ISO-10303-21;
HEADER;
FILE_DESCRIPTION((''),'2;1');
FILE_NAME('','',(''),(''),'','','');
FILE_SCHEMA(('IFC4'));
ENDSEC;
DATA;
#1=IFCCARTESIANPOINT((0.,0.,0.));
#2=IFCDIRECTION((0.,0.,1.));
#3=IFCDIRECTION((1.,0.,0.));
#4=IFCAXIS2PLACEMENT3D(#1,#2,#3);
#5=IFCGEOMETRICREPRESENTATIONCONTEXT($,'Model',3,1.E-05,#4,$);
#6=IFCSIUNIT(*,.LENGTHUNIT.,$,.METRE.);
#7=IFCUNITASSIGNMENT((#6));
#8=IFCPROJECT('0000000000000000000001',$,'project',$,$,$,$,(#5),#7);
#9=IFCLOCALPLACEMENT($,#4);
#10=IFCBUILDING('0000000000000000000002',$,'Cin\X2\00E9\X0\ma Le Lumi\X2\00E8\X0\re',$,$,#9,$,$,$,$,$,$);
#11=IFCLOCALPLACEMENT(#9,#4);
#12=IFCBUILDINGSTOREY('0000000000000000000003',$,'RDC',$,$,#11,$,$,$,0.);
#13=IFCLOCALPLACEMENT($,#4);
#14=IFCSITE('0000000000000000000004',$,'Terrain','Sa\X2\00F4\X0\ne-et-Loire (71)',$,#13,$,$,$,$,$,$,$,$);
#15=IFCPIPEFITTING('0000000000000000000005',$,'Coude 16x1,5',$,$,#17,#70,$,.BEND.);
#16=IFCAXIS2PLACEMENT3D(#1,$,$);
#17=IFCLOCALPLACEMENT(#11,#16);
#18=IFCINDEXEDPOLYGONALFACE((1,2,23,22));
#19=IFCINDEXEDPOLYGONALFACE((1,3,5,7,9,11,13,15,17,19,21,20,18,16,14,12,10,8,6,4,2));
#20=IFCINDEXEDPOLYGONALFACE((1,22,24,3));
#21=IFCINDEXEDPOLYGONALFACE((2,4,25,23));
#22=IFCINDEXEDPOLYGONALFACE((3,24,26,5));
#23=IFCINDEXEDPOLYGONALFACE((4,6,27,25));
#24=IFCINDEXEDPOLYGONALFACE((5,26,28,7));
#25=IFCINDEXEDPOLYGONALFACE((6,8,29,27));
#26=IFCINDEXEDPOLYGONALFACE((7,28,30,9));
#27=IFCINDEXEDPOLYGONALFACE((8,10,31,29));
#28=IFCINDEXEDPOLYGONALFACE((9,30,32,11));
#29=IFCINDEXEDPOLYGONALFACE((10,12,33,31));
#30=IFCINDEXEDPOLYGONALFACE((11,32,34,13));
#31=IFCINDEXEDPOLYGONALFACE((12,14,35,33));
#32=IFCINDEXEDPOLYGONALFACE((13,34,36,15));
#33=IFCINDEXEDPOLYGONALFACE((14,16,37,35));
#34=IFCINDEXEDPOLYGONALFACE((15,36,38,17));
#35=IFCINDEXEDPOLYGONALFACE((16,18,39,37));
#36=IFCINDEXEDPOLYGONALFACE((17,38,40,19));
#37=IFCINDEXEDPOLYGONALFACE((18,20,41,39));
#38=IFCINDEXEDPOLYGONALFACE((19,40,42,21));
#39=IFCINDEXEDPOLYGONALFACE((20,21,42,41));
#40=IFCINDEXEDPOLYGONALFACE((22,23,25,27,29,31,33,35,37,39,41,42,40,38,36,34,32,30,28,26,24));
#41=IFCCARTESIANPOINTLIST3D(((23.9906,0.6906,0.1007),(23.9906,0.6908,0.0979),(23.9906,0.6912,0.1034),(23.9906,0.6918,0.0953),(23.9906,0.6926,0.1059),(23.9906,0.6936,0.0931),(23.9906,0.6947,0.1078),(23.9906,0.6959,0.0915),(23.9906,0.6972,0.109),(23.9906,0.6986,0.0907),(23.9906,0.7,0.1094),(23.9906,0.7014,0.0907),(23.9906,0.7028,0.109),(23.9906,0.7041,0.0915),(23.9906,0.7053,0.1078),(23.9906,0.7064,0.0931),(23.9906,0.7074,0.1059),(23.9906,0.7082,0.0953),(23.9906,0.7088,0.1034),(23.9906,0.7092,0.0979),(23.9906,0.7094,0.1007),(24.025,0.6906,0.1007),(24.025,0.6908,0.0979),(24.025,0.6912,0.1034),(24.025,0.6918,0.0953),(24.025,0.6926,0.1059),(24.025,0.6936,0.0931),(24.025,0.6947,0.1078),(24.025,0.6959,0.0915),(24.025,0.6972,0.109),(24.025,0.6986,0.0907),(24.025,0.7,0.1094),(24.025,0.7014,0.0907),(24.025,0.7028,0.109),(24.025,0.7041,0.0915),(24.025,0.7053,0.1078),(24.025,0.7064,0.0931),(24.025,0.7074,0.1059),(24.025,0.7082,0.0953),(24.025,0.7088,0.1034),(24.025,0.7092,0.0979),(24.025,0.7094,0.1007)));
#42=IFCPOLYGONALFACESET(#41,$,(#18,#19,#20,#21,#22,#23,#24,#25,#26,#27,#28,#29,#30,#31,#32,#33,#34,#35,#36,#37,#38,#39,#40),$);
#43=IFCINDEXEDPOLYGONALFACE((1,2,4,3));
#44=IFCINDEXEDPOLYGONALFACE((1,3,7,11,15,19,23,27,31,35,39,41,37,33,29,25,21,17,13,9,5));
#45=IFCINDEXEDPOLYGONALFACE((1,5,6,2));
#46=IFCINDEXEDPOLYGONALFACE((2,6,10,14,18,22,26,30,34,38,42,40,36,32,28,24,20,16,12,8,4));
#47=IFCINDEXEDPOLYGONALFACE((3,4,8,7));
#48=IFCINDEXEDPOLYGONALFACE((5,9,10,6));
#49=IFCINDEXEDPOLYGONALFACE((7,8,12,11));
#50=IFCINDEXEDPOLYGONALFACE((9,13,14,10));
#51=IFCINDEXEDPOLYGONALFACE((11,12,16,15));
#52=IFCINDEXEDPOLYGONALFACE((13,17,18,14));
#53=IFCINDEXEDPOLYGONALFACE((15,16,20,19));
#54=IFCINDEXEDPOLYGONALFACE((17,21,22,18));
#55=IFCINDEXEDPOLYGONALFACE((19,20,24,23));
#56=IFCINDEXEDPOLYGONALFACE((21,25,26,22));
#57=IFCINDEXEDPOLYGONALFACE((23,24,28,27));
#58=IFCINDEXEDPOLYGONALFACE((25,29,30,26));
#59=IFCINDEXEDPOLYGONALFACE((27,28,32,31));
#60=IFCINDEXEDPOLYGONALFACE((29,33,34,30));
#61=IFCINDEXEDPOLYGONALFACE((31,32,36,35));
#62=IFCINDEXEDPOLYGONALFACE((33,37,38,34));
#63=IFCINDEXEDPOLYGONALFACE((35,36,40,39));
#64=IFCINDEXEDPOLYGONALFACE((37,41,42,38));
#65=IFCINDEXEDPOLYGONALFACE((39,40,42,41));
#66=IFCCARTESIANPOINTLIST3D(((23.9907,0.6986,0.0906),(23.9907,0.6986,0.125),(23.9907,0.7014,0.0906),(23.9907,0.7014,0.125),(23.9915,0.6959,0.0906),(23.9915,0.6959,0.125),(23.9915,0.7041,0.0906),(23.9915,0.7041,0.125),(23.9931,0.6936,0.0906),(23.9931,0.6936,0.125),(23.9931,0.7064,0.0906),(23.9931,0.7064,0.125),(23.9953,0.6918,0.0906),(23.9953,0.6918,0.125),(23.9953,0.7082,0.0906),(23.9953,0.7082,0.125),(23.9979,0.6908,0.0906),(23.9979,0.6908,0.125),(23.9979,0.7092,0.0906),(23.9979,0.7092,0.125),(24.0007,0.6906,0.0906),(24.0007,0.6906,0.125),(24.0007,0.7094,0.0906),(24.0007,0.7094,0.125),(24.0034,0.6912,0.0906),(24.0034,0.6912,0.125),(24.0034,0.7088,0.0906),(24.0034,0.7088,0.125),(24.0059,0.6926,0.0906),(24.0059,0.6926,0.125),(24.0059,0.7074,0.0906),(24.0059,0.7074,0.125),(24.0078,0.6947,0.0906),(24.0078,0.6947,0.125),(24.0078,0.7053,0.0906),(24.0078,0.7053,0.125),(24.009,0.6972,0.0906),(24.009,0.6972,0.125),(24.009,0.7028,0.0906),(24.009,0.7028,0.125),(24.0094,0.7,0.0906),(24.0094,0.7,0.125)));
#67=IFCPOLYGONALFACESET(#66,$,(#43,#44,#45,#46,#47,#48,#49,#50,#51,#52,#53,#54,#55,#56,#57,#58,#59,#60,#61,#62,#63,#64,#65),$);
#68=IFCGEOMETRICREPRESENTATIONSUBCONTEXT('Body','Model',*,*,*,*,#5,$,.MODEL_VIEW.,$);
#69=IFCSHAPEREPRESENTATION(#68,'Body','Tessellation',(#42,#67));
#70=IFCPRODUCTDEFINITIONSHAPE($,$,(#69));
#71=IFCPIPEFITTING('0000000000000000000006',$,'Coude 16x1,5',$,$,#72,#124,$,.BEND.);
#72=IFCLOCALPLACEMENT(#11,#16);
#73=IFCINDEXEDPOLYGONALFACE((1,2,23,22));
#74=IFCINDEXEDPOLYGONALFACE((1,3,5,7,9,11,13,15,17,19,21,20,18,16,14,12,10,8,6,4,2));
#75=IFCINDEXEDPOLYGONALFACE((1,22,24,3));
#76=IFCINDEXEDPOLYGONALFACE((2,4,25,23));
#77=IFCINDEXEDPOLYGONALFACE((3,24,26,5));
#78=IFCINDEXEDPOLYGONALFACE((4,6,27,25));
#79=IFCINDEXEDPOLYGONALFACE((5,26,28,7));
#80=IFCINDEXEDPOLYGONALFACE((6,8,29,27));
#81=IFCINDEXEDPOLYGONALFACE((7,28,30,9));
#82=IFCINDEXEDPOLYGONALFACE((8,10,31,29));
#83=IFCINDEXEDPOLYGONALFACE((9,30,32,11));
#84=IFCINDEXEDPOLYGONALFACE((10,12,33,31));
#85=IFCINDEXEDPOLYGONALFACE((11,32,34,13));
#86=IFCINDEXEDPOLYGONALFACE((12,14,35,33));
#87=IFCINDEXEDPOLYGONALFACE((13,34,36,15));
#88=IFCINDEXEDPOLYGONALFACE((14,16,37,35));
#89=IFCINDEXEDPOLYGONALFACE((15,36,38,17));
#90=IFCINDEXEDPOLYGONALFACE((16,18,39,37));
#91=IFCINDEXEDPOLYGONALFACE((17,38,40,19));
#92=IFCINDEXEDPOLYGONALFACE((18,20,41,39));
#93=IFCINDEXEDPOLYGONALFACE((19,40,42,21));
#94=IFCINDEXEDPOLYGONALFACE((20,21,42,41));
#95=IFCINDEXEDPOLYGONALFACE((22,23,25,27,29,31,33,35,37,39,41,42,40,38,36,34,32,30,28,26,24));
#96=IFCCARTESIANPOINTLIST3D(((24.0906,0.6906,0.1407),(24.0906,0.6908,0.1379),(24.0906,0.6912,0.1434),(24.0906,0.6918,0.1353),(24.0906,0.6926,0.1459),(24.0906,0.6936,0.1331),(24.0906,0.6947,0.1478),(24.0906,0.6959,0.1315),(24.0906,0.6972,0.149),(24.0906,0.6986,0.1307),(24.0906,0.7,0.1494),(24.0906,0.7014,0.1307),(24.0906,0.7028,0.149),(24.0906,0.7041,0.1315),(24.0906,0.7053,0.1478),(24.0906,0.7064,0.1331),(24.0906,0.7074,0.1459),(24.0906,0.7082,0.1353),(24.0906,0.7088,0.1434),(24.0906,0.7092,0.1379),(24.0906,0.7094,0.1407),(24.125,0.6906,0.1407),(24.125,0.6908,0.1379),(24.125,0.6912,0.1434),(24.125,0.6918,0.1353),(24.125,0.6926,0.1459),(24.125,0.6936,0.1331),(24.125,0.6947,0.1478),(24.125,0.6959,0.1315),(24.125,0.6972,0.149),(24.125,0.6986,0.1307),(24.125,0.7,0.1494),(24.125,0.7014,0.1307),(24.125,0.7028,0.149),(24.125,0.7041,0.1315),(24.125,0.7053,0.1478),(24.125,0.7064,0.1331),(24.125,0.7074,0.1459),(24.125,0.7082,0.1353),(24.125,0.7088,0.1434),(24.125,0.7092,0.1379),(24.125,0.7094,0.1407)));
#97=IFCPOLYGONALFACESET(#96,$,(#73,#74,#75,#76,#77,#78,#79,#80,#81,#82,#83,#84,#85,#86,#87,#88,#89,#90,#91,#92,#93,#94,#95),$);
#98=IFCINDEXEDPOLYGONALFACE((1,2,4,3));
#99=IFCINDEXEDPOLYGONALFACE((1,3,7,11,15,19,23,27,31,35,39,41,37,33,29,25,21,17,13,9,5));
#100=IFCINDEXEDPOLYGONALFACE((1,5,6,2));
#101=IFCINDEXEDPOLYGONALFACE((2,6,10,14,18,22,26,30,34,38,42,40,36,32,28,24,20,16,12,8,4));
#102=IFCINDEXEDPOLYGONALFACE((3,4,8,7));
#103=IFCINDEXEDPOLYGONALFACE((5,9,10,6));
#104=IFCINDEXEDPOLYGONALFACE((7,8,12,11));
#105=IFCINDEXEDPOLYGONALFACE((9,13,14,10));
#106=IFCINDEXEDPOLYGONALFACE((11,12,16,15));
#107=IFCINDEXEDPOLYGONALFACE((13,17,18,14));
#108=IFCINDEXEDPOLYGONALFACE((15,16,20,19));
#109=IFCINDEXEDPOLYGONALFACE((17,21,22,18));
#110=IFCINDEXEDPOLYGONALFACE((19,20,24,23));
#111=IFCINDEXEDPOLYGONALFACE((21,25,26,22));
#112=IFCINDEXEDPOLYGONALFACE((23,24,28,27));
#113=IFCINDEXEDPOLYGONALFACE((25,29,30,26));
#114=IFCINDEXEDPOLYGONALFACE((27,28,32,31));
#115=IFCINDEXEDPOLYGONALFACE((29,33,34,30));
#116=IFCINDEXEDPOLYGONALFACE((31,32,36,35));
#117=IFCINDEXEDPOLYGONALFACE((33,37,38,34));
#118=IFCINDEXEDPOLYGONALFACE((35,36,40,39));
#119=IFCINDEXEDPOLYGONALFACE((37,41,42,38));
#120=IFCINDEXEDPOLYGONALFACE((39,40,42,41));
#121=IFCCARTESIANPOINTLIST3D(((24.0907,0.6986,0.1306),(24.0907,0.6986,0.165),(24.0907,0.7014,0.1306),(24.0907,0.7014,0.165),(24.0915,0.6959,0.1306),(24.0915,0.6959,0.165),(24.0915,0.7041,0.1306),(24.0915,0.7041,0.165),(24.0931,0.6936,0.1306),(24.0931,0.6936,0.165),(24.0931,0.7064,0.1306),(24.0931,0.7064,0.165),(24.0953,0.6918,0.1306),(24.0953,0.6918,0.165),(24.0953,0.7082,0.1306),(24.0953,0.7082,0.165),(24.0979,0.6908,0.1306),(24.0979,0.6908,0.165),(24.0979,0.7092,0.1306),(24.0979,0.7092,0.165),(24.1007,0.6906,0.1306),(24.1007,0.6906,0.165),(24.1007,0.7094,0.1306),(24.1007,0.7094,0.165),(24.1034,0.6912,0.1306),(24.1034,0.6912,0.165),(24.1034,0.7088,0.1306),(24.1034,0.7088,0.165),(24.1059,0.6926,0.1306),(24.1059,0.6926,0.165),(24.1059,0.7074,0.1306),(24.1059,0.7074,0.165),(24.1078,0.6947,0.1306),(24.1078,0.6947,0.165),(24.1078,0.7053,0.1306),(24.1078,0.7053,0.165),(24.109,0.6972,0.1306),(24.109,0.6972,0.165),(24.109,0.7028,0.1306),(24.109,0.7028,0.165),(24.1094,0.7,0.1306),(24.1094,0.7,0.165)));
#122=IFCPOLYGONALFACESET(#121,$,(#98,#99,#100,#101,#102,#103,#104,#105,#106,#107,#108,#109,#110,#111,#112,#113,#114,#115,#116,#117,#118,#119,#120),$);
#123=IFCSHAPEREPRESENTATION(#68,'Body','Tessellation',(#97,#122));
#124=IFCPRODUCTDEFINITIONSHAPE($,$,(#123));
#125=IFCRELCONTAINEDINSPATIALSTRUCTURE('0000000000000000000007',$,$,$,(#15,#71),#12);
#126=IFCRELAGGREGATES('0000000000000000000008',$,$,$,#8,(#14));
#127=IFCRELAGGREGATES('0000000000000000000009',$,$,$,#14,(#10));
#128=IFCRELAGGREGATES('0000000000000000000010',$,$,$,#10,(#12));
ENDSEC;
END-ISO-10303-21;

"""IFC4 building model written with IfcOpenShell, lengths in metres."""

from ifc_helpers import new_model, si_unit, frame, origin_with_axes, place, context, subcontext, project, spatial, circle, extrude, element, save


model = new_model("IFC4")

# Units and contexts
model_context = context("Model", 3, precision=1e-05, world=origin_with_axes())
body_context = subcontext(model_context, "Body", "Model", "MODEL_VIEW")
ifc_project = project(units=[si_unit("LENGTHUNIT", "METRE")], contexts=[model_context])

# Site, building, storey
site_placement = place(None, origin_with_axes())
site = spatial("IfcSite", under=ifc_project, at=site_placement, Name="Terrain", Description="Saône-et-Loire (71)")
building_placement = place(None, origin_with_axes())
building = spatial("IfcBuilding", under=site, at=building_placement, Name="Cinéma Le Lumière")
storey_placement = place(building_placement, origin_with_axes())
storey = spatial("IfcBuildingStorey", under=building, at=storey_placement, Name="RDC", Elevation=0.0)

# Pipe fittings
pipe_fitting_1_placement = place(storey_placement, frame((24.0, 0.7, 0.1), z_axis=(0.0, 0.0, 1.0), x_axis=(1.0, 0.0, 0.0)))
element("IfcPipeFitting", 1, at=pipe_fitting_1_placement, inside=storey, Name="Coude 16x1,5", PredefinedType="BEND", context=body_context, shape_type="SweptSolid", body=[
    extrude(circle(Radius=0.0094), frame((-0.0094, 0.0, 0.0), z_axis=(1.0, 0.0, 0.0), x_axis=(0.0, 0.0, 1.0)), (0.0, 0.0, 1.0), 0.0344),
    extrude(circle(Radius=0.0094), frame((0.0, 0.0, -0.0094), z_axis=(0.0, 0.0, 1.0), x_axis=(1.0, 0.0, 0.0)), (0.0, 0.0, 1.0), 0.0344),
])
pipe_fitting_2_placement = place(storey_placement, frame((24.1, 0.7, 0.14), z_axis=(0.0, 0.0, 1.0), x_axis=(1.0, 0.0, 0.0)))
element("IfcPipeFitting", 2, at=pipe_fitting_2_placement, inside=storey, Name="Coude 16x1,5", PredefinedType="BEND", context=body_context, shape_type="SweptSolid", body=[
    extrude(circle(Radius=0.0094), frame((-0.0094, 0.0, 0.0), z_axis=(1.0, 0.0, 0.0), x_axis=(0.0, 0.0, 1.0)), (0.0, 0.0, 1.0), 0.0344),
    extrude(circle(Radius=0.0094), frame((0.0, 0.0, -0.0094), z_axis=(0.0, 0.0, 1.0), x_axis=(1.0, 0.0, 0.0)), (0.0, 0.0, 1.0), 0.0344),
])

save(model, "model.ifc")
